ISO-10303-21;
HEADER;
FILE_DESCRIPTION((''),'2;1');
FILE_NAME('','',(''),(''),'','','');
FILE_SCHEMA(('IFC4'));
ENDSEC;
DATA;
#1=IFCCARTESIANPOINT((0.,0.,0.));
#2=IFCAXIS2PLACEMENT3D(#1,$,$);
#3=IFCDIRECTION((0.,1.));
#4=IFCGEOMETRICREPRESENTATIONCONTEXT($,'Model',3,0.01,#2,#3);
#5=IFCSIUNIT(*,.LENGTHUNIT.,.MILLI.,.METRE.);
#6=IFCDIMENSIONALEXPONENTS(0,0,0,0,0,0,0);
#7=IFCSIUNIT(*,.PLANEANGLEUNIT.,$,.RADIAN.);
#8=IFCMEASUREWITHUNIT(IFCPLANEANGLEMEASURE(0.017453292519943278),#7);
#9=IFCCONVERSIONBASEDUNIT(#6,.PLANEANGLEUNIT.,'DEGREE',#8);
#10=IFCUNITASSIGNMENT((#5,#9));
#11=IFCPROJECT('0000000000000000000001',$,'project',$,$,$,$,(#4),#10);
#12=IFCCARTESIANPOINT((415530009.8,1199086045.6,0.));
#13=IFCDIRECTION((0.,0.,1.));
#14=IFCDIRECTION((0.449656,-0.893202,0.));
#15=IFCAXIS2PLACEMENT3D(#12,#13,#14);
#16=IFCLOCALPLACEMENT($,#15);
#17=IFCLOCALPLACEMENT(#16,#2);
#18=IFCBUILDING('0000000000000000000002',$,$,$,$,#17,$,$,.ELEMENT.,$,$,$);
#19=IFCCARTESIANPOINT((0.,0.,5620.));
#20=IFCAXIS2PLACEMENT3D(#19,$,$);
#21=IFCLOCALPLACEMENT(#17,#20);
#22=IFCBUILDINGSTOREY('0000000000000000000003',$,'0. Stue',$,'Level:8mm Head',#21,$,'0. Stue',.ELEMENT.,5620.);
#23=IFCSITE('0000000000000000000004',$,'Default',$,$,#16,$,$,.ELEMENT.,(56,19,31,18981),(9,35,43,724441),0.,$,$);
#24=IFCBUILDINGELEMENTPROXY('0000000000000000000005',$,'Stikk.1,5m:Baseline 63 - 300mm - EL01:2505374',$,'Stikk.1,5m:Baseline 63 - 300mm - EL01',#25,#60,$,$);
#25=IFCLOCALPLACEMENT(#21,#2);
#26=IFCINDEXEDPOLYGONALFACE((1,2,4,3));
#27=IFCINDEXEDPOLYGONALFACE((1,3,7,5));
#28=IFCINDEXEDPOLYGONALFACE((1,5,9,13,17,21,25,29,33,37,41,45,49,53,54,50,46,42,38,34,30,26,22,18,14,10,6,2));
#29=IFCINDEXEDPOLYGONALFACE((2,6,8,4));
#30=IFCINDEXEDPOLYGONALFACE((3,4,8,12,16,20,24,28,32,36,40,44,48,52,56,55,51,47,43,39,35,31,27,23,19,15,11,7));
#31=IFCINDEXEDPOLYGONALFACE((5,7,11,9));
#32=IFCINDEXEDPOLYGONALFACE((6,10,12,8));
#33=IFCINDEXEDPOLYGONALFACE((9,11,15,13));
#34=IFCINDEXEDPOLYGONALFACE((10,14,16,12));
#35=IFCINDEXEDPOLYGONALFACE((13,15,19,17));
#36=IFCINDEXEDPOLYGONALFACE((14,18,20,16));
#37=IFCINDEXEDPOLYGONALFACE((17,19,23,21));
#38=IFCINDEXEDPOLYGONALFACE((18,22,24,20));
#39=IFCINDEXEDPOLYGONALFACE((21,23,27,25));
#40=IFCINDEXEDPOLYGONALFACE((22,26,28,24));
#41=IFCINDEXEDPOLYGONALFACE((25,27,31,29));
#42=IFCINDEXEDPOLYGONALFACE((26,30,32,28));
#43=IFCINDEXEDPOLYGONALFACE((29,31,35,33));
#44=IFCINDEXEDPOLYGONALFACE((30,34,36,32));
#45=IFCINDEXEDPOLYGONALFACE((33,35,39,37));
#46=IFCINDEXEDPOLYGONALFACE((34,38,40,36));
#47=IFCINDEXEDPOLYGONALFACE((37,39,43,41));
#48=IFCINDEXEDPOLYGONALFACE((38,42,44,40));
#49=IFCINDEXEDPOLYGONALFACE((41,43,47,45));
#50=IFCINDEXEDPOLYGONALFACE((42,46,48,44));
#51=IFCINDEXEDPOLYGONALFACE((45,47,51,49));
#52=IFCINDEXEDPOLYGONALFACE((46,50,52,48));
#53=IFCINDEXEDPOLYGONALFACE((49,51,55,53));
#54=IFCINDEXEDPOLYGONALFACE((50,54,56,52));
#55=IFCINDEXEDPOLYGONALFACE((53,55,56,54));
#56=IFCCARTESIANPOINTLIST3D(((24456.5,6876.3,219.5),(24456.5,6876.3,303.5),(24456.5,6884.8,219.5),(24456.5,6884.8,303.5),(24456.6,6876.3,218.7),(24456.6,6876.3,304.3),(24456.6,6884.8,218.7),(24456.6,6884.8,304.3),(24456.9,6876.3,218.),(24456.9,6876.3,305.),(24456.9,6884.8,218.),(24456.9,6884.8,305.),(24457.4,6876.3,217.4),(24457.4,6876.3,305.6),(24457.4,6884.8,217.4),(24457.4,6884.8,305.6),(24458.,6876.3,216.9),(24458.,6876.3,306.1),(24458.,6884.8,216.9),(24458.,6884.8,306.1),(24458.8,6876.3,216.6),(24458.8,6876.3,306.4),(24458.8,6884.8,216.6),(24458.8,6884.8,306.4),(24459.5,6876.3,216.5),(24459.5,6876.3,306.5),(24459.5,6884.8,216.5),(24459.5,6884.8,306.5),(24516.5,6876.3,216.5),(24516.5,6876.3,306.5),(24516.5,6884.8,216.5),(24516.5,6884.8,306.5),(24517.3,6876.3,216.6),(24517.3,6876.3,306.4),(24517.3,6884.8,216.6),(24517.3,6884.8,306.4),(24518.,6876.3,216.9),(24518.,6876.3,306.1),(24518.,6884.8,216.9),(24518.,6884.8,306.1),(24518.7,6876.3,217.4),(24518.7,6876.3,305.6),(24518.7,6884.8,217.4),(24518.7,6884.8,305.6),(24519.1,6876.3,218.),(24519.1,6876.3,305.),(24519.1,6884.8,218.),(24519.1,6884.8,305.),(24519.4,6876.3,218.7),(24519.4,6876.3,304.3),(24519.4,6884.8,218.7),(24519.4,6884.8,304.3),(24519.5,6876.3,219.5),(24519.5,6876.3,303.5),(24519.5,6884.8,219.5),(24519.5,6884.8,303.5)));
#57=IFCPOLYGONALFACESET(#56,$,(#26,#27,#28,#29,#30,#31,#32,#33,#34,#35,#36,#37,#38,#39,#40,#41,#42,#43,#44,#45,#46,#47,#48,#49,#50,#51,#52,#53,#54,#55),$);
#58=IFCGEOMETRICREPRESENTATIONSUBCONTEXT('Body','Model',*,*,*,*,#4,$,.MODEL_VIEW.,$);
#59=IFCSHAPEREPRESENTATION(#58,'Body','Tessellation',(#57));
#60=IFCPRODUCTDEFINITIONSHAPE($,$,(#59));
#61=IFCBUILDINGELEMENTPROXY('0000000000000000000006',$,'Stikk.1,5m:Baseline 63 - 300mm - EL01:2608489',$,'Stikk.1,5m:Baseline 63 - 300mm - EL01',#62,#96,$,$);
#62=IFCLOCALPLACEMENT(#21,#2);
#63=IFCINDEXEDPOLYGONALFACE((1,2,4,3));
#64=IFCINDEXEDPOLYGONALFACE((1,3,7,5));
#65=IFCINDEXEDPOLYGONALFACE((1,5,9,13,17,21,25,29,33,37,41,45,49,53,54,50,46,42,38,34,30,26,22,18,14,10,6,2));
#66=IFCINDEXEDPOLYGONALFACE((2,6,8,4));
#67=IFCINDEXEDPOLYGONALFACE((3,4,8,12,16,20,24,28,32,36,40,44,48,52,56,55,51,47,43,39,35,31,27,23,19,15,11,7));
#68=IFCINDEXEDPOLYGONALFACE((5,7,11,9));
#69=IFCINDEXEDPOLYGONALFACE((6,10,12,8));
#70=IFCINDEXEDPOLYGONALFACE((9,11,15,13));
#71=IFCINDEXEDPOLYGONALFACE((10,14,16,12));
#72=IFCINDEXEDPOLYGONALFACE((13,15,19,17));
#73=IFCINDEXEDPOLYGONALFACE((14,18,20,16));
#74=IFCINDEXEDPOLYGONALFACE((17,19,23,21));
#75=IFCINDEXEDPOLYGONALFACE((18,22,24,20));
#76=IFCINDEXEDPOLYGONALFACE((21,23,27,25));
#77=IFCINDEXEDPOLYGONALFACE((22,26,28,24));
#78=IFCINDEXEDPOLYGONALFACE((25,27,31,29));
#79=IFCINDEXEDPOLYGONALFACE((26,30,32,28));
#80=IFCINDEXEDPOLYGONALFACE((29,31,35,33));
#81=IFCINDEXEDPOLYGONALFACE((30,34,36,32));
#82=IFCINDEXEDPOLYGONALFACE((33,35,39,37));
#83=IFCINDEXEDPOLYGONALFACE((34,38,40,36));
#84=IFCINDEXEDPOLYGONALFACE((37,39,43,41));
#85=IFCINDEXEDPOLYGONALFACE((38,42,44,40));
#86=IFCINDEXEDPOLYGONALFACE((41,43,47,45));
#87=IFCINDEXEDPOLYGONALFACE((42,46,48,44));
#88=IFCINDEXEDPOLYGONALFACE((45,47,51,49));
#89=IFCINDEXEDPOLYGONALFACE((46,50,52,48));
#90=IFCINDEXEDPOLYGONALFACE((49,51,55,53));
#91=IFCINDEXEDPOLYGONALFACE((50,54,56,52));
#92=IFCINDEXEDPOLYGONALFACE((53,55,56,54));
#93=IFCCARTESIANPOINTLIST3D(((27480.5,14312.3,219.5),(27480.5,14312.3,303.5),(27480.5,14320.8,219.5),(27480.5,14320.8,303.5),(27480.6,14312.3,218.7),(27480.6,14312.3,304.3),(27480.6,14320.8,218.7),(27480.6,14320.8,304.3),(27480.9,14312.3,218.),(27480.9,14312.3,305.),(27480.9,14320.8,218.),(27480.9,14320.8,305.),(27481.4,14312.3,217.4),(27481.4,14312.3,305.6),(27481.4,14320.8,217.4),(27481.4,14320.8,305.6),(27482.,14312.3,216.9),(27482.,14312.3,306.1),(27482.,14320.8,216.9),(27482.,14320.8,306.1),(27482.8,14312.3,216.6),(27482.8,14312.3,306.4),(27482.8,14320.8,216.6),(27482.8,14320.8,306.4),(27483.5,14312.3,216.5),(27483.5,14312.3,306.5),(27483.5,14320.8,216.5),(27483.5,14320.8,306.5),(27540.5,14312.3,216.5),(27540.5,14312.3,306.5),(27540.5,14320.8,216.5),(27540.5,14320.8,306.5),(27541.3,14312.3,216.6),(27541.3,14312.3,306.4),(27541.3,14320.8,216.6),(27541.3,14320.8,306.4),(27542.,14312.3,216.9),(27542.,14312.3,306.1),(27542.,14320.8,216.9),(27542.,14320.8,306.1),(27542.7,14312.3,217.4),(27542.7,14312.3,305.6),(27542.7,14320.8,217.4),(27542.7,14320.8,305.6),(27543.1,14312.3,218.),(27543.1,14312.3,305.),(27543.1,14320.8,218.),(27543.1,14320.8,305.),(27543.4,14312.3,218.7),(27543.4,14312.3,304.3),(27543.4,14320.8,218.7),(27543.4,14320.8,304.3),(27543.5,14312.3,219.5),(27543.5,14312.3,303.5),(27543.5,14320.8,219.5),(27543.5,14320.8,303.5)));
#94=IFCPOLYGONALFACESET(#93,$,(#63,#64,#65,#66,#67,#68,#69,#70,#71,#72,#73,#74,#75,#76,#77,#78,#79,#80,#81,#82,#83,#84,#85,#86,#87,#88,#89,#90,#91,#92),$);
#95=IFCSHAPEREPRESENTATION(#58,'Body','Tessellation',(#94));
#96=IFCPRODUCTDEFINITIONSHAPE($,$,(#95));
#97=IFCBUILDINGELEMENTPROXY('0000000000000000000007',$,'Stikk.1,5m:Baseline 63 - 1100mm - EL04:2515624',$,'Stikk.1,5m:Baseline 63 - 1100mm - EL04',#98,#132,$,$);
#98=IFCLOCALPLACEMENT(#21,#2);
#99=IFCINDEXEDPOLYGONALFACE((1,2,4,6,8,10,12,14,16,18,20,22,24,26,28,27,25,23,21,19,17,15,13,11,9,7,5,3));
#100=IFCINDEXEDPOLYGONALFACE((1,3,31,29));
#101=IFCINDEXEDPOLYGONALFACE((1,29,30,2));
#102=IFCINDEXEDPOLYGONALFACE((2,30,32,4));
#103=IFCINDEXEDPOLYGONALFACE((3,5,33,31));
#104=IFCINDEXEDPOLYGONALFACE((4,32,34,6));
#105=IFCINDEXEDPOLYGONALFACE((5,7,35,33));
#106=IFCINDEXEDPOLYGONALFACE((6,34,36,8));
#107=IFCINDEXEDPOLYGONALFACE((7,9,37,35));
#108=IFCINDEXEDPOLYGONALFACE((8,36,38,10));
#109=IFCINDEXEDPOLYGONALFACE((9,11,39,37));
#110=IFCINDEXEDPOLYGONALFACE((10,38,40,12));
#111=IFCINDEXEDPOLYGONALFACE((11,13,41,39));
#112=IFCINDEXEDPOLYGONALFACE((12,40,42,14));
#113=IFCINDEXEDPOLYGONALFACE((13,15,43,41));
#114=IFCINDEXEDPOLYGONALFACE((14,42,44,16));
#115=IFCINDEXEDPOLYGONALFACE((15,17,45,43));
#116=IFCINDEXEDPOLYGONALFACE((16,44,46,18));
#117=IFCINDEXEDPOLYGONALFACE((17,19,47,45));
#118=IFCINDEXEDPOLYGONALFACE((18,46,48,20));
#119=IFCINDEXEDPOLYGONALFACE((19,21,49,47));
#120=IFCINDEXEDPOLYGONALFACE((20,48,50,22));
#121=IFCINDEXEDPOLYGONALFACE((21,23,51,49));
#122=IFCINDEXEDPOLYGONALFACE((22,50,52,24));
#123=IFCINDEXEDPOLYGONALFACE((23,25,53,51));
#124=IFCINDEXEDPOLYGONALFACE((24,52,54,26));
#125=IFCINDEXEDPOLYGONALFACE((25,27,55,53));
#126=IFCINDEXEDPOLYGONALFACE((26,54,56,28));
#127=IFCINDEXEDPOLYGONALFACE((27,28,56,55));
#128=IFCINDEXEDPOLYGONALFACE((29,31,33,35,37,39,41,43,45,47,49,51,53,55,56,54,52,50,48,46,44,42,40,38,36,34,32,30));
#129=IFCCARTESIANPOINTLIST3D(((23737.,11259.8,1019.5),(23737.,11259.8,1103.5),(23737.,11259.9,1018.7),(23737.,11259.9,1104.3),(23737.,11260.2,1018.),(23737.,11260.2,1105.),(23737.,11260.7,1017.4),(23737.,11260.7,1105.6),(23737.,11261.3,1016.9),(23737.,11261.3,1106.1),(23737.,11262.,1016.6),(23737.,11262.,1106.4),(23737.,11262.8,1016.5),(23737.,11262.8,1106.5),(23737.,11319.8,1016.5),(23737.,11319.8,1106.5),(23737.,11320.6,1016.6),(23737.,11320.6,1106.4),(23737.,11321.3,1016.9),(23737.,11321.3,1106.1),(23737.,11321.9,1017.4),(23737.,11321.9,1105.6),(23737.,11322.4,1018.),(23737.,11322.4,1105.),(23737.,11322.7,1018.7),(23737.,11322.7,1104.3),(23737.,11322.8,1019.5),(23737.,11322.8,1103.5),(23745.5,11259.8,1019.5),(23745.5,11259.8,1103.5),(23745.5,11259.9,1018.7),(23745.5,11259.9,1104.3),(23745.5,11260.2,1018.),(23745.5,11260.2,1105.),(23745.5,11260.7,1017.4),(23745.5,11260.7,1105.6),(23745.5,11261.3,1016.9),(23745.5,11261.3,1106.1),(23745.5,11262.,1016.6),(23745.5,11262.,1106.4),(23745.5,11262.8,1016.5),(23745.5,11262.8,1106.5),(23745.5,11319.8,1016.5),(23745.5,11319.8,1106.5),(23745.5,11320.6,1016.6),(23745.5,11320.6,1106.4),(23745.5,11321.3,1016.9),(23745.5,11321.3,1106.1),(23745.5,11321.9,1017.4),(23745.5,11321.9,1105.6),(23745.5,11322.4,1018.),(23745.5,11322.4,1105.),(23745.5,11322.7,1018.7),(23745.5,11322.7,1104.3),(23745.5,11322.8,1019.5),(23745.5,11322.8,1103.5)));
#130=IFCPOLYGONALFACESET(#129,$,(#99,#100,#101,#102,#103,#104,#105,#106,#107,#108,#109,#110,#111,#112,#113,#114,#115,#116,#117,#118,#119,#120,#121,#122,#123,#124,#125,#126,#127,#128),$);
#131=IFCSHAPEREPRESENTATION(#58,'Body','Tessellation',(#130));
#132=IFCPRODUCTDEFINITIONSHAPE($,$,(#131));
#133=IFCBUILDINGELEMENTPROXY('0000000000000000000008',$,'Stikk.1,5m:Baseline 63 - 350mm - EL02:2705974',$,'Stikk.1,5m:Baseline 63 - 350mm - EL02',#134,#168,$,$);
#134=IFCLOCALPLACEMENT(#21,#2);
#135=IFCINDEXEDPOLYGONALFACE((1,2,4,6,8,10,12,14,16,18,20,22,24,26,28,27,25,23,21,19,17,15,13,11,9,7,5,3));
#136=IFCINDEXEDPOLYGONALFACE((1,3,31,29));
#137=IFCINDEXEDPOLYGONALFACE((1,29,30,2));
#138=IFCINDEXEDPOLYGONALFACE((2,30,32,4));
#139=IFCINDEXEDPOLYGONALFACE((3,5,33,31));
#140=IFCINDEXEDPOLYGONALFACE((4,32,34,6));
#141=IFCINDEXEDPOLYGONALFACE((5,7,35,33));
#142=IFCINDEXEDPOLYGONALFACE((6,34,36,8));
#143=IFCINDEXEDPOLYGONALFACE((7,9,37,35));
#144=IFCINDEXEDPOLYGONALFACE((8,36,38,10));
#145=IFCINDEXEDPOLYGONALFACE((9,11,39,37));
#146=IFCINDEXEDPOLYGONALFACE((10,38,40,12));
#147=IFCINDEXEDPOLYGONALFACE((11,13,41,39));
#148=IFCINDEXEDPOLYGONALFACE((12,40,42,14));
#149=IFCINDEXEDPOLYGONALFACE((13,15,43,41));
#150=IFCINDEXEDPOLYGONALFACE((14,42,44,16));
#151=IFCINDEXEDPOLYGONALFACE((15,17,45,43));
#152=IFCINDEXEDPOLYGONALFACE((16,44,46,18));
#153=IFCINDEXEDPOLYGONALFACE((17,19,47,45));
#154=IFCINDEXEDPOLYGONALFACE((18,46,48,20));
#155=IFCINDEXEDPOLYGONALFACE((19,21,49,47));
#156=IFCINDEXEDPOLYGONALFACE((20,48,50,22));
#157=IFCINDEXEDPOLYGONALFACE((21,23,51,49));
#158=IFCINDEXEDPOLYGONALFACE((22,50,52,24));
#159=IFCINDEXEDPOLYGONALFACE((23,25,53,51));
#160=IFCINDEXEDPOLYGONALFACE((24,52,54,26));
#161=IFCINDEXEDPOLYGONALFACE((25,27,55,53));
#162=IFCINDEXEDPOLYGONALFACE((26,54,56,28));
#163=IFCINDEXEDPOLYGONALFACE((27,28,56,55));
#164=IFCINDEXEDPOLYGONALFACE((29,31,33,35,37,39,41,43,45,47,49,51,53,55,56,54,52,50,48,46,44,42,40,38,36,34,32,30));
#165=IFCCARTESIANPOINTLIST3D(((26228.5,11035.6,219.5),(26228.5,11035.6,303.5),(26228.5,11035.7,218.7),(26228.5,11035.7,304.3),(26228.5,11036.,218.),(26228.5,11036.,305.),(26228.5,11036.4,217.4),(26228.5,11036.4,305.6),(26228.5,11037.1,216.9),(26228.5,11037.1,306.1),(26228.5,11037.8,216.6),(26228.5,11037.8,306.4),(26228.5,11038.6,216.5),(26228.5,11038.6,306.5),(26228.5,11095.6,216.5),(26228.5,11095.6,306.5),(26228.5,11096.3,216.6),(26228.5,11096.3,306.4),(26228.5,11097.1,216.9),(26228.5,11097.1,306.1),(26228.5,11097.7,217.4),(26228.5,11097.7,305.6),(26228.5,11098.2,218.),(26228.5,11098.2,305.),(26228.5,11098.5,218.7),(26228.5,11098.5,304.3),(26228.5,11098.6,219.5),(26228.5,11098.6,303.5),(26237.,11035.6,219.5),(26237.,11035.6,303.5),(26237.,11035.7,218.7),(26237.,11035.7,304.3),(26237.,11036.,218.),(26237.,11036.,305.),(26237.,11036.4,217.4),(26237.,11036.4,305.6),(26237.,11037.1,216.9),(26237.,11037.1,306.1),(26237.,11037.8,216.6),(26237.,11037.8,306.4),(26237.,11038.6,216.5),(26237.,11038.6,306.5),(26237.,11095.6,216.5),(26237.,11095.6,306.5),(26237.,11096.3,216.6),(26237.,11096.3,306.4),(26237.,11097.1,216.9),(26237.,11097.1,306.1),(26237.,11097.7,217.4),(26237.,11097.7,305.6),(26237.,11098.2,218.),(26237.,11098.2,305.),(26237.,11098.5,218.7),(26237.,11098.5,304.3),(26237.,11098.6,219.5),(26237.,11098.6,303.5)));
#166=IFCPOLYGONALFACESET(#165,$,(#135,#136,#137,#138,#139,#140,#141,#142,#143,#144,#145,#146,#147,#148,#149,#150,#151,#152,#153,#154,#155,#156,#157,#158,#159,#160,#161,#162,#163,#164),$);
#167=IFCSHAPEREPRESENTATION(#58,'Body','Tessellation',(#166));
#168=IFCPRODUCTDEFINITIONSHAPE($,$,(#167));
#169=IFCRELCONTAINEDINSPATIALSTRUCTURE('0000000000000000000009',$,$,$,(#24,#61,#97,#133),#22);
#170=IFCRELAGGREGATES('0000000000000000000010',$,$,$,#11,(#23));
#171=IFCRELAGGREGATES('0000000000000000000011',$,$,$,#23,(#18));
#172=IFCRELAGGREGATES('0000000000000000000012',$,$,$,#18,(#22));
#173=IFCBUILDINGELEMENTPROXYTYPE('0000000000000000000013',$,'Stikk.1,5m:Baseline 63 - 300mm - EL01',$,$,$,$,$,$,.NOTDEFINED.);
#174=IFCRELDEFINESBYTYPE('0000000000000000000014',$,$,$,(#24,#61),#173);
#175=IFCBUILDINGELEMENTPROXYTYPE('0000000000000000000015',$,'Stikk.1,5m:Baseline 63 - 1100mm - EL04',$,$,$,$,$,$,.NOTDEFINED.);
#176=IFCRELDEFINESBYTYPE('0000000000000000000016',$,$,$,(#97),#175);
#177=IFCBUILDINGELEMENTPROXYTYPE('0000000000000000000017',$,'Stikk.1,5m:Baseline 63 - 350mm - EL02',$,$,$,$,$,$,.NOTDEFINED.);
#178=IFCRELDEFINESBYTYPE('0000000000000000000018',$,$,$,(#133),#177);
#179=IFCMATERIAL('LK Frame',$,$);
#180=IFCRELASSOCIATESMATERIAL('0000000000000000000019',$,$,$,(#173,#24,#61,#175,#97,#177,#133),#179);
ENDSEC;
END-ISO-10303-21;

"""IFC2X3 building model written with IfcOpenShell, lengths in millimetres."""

from ifc_helpers import new_model, entity, si_unit, converted_unit, direction, frame, frame_2d, origin, place, context, subcontext, project, spatial, polyline, circle_curve, parameter, trimmed, segment, composite_curve, outline, extrude, source, transform, mapped, material, type_object, type_shapes, element, save


model = new_model("IFC2X3")

# Units and contexts
model_context = context("Model", 3, precision=0.01, world=origin(), true_north=direction((0.0, 1.0)))
body_context = subcontext(model_context, "Body", "Model", "MODEL_VIEW")
ifc_project = project(units=[si_unit("LENGTHUNIT", "METRE", prefix="MILLI"), converted_unit("PLANEANGLEUNIT", "DEGREE", entity("IfcPlaneAngleMeasure", 0.017453292519943278), si_unit("PLANEANGLEUNIT", "RADIAN"), dimensions=[0, 0, 0, 0, 0, 0, 0])], contexts=[model_context])

# Site, building, storey
site_placement = place(None, frame((415530009.8, 1199086045.6, 0.0), z_axis=(0.0, 0.0, 1.0), x_axis=(0.449656, -0.893202, 0.0)))
site = spatial("IfcSite", under=ifc_project, at=site_placement, Name="Default", CompositionType="ELEMENT", RefLatitude=(56, 19, 31, 18981), RefLongitude=(9, 35, 43, 724441), RefElevation=0.0)
building_placement = place(site_placement, origin())
building = spatial("IfcBuilding", under=site, at=building_placement, CompositionType="ELEMENT")
storey_placement = place(building_placement, frame((0.0, 0.0, 5620.0)))
storey = spatial("IfcBuildingStorey", under=building, at=storey_placement, Name="0. Stue", ObjectType="Level:8mm Head", LongName="0. Stue", CompositionType="ELEMENT", Elevation=5620.0)

# Building element proxies
ifc_material_1 = material(Name="LK Frame")
building_element_proxy_type_1 = type_object("IfcBuildingElementProxyType", Name="Stikk.1,5m:Baseline 63 - 300mm - EL01", PredefinedType="NOTDEFINED", material=ifc_material_1)
shared_shape_1 = source(origin(), body_context, "Body", "SweptSolid", [
    extrude(outline(composite_curve([segment(polyline([(-42.0, -31.5), (42.0, -31.5)]), True, "CONTINUOUS"), segment(trimmed(circle_curve(frame_2d((42.0, -28.5), x_axis=(-1.0, 0.0)), 3.0), [parameter(90.0)], [parameter(180.0)], True, "PARAMETER"), True, "CONTINUOUS"), segment(polyline([(45.0, -28.5), (45.0, 28.5)]), True, "CONTINUOUS"), segment(trimmed(circle_curve(frame_2d((42.0, 28.5), x_axis=(-1.0, 0.0)), 3.0), [parameter(180.0)], [parameter(270.0)], True, "PARAMETER"), True, "CONTINUOUS"), segment(polyline([(42.0, 31.5), (-42.0, 31.5)]), True, "CONTINUOUS"), segment(trimmed(circle_curve(frame_2d((-42.0, 28.5), x_axis=(1.0, 0.0)), 3.0), [parameter(90.0)], [parameter(180.0)], True, "PARAMETER"), True, "CONTINUOUS"), segment(polyline([(-45.0, 28.5), (-45.0, -28.5)]), True, "CONTINUOUS"), segment(trimmed(circle_curve(frame_2d((-42.0, -28.5), x_axis=(1.0, 0.0)), 3.0), [parameter(180.0)], [parameter(270.0)], True, "PARAMETER"), True, "CONTINUOUS")], self_intersect=False)), frame((0.0, -38.5, 0.0), z_axis=(0.0, 0.0, 1.0), x_axis=(0.0, 1.0, 0.0)), (0.0, 0.0, 1.0), 8.5),
])
type_shapes(building_element_proxy_type_1, [shared_shape_1])
for number, where, z_axis, x_axis, name in (
    (1, (24488.0, 6876.3, 300.0), (0.0, 1.0, 0.0), (-1.0, 0.0, 0.0), "Stikk.1,5m:Baseline 63 - 300mm - EL01:2505374"),
    (2, (27512.0, 14320.8, 300.0), (0.0, -1.0, 0.0), (1.0, 0.0, 0.0), "Stikk.1,5m:Baseline 63 - 300mm - EL01:2608489"),
):
    element("IfcBuildingElementProxy", number, at=place(storey_placement, frame(where, z_axis=z_axis, x_axis=x_axis)), inside=storey, type_object=building_element_proxy_type_1, material=ifc_material_1, Name=name, ObjectType="Stikk.1,5m:Baseline 63 - 300mm - EL01", context=body_context, shape_type="MappedRepresentation", body=[
        mapped(shared_shape_1, transform((0.0, 0.0, 0.0), scale=1.0)),
    ])
building_element_proxy_type_2 = type_object("IfcBuildingElementProxyType", Name="Stikk.1,5m:Baseline 63 - 1100mm - EL04", PredefinedType="NOTDEFINED", material=ifc_material_1)
shared_shape_2 = source(origin(), body_context, "Body", "SweptSolid", [
    extrude(outline(composite_curve([segment(polyline([(-42.0, -31.5), (42.0, -31.5)]), True, "CONTINUOUS"), segment(trimmed(circle_curve(frame_2d((42.0, -28.5), x_axis=(-1.0, 0.0)), 3.0), [parameter(90.0)], [parameter(180.0)], True, "PARAMETER"), True, "CONTINUOUS"), segment(polyline([(45.0, -28.5), (45.0, 28.5)]), True, "CONTINUOUS"), segment(trimmed(circle_curve(frame_2d((42.0, 28.5), x_axis=(-1.0, 0.0)), 3.0), [parameter(180.0)], [parameter(270.0)], True, "PARAMETER"), True, "CONTINUOUS"), segment(polyline([(42.0, 31.5), (-42.0, 31.5)]), True, "CONTINUOUS"), segment(trimmed(circle_curve(frame_2d((-42.0, 28.5), x_axis=(1.0, 0.0)), 3.0), [parameter(90.0)], [parameter(180.0)], True, "PARAMETER"), True, "CONTINUOUS"), segment(polyline([(-45.0, 28.5), (-45.0, -28.5)]), True, "CONTINUOUS"), segment(trimmed(circle_curve(frame_2d((-42.0, -28.5), x_axis=(1.0, 0.0)), 3.0), [parameter(180.0)], [parameter(270.0)], True, "PARAMETER"), True, "CONTINUOUS")], self_intersect=False)), frame((0.0, -38.5, 0.0), z_axis=(0.0, 0.0, 1.0), x_axis=(0.0, 1.0, 0.0)), (0.0, 0.0, 1.0), 8.5),
])
type_shapes(building_element_proxy_type_2, [shared_shape_2])
proxy_1_placement = place(storey_placement, frame((23737.0, 11291.3, 1100.0), z_axis=(1.0, 0.0, 0.0), x_axis=(0.0, 1.0, 0.0)))
element("IfcBuildingElementProxy", 3, at=proxy_1_placement, inside=storey, type_object=building_element_proxy_type_2, material=ifc_material_1, Name="Stikk.1,5m:Baseline 63 - 1100mm - EL04:2515624", ObjectType="Stikk.1,5m:Baseline 63 - 1100mm - EL04", context=body_context, shape_type="MappedRepresentation", body=[
    mapped(shared_shape_2, transform((0.0, 0.0, 0.0), scale=1.0)),
])
building_element_proxy_type_3 = type_object("IfcBuildingElementProxyType", Name="Stikk.1,5m:Baseline 63 - 350mm - EL02", PredefinedType="NOTDEFINED", material=ifc_material_1)
shared_shape_3 = source(origin(), body_context, "Body", "SweptSolid", [
    extrude(outline(composite_curve([segment(polyline([(-42.0, -31.5), (42.0, -31.5)]), True, "CONTINUOUS"), segment(trimmed(circle_curve(frame_2d((42.0, -28.5), x_axis=(-1.0, 0.0)), 3.0), [parameter(90.0)], [parameter(180.0)], True, "PARAMETER"), True, "CONTINUOUS"), segment(polyline([(45.0, -28.5), (45.0, 28.5)]), True, "CONTINUOUS"), segment(trimmed(circle_curve(frame_2d((42.0, 28.5), x_axis=(-1.0, 0.0)), 3.0), [parameter(180.0)], [parameter(270.0)], True, "PARAMETER"), True, "CONTINUOUS"), segment(polyline([(42.0, 31.5), (-42.0, 31.5)]), True, "CONTINUOUS"), segment(trimmed(circle_curve(frame_2d((-42.0, 28.5), x_axis=(1.0, 0.0)), 3.0), [parameter(90.0)], [parameter(180.0)], True, "PARAMETER"), True, "CONTINUOUS"), segment(polyline([(-45.0, 28.5), (-45.0, -28.5)]), True, "CONTINUOUS"), segment(trimmed(circle_curve(frame_2d((-42.0, -28.5), x_axis=(1.0, 0.0)), 3.0), [parameter(180.0)], [parameter(270.0)], True, "PARAMETER"), True, "CONTINUOUS")], self_intersect=False)), frame((0.0, -38.5, 0.0), z_axis=(0.0, 0.0, 1.0), x_axis=(0.0, 1.0, 0.0)), (0.0, 0.0, 1.0), 8.5),
])
type_shapes(building_element_proxy_type_3, [shared_shape_3])
proxy_2_placement = place(storey_placement, frame((26237.0, 11067.1, 300.0), z_axis=(-1.0, 0.0, 0.0), x_axis=(0.0, -1.0, 0.0)))
element("IfcBuildingElementProxy", 4, at=proxy_2_placement, inside=storey, type_object=building_element_proxy_type_3, material=ifc_material_1, Name="Stikk.1,5m:Baseline 63 - 350mm - EL02:2705974", ObjectType="Stikk.1,5m:Baseline 63 - 350mm - EL02", context=body_context, shape_type="MappedRepresentation", body=[
    mapped(shared_shape_3, transform((0.0, 0.0, 0.0), scale=1.0)),
])

save(model, "model.ifc")
